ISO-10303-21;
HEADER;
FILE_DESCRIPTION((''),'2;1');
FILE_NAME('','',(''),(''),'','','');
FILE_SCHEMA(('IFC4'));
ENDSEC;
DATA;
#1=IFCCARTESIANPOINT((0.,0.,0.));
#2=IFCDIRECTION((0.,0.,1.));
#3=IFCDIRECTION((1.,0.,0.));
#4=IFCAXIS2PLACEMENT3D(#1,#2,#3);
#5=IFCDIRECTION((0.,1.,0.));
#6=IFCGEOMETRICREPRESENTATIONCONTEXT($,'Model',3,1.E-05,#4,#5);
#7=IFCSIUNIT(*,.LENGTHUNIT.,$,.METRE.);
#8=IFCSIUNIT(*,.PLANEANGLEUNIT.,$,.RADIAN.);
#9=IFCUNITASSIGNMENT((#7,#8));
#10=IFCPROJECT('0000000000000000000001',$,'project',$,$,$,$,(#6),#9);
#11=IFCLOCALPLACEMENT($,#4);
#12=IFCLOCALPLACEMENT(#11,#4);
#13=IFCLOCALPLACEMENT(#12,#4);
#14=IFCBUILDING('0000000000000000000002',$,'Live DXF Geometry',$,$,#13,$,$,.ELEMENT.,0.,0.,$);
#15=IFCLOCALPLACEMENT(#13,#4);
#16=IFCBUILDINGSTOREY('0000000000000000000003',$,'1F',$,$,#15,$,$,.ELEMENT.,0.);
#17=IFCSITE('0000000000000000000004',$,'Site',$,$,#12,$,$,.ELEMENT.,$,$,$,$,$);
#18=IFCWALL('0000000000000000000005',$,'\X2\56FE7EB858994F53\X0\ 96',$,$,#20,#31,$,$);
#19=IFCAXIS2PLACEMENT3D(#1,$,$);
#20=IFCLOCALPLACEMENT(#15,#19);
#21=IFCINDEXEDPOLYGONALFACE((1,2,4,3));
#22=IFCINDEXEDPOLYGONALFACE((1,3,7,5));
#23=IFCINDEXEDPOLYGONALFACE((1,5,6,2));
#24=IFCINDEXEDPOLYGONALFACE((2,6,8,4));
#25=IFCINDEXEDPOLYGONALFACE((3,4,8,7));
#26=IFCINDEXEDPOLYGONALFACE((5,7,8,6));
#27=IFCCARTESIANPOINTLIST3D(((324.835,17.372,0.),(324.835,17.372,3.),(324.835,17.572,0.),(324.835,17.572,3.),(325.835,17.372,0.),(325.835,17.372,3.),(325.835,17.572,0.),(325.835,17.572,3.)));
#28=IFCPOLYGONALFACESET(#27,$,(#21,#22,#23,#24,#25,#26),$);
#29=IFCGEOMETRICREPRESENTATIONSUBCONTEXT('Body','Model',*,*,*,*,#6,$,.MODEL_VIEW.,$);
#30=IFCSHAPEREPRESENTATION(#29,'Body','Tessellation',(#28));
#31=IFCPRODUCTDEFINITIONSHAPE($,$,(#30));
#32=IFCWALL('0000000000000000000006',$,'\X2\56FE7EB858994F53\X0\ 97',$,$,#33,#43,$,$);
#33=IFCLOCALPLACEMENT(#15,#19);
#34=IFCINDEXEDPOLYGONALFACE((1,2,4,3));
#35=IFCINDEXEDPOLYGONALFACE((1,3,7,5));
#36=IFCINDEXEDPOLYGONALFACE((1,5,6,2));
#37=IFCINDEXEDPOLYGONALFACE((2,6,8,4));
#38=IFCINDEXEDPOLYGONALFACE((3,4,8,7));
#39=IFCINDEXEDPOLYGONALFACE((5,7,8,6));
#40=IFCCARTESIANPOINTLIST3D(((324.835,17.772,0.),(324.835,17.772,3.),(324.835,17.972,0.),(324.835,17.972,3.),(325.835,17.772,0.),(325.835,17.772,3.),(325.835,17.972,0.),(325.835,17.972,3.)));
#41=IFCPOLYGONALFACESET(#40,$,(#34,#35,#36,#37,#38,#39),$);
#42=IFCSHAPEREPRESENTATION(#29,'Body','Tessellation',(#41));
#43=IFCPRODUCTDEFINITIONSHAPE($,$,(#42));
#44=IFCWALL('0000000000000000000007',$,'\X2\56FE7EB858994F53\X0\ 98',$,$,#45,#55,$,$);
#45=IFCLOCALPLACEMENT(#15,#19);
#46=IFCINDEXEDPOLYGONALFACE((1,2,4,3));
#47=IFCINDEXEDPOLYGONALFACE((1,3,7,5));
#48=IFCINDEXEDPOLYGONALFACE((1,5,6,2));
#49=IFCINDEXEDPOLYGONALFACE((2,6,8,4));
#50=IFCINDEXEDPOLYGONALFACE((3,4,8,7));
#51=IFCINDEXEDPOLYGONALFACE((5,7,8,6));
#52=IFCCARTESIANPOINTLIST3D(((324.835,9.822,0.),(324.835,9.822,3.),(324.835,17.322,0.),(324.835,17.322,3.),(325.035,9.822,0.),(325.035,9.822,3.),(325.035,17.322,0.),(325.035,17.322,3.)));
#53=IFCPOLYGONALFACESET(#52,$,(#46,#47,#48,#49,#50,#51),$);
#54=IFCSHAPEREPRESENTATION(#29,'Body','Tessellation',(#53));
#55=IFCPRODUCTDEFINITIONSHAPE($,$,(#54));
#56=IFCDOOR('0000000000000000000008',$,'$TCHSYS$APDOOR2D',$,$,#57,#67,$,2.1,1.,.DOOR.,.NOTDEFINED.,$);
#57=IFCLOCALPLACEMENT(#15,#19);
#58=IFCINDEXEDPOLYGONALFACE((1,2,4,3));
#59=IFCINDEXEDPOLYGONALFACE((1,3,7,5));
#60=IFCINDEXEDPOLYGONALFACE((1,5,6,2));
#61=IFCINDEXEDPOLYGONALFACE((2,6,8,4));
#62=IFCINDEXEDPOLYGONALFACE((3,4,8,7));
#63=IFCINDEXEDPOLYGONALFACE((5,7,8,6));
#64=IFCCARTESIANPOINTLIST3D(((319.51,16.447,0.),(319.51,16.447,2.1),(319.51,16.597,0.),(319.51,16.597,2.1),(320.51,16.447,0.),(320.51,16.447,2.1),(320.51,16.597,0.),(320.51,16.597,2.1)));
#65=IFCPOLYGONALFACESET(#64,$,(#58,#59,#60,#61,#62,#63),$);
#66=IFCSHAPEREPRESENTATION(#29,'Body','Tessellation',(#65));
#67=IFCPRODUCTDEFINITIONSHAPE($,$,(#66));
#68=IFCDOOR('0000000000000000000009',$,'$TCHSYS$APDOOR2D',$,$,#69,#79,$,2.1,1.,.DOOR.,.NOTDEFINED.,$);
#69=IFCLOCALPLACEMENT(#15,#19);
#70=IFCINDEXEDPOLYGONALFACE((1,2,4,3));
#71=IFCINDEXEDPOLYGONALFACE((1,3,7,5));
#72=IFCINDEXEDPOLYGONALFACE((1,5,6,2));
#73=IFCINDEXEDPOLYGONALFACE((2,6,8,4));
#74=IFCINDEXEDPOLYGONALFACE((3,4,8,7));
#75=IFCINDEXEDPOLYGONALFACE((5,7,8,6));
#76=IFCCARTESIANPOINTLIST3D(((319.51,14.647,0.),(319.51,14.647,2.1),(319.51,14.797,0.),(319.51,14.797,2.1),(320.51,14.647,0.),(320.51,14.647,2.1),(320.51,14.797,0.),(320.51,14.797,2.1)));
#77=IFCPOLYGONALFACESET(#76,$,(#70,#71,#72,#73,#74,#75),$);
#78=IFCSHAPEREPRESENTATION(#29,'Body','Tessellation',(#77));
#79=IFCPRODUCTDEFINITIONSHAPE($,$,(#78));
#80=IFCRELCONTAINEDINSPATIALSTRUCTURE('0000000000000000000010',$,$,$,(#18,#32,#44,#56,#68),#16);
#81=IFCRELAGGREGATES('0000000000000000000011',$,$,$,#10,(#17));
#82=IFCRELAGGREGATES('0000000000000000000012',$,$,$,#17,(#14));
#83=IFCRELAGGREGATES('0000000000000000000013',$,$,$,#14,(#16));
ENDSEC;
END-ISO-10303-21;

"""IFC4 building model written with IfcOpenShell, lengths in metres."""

from ifc_helpers import new_model, si_unit, direction, frame, frame_2d, origin_with_axes, place, context, subcontext, project, spatial, rectangle, extrude, element, save


model = new_model("IFC4")

# Units and contexts
model_context = context("Model", 3, precision=1e-05, world=origin_with_axes(), true_north=direction((0.0, 1.0, 0.0)))
body_context = subcontext(model_context, "Body", "Model", "MODEL_VIEW")
ifc_project = project(units=[si_unit("LENGTHUNIT", "METRE"), si_unit("PLANEANGLEUNIT", "RADIAN")], contexts=[model_context])

# Site, building, storey
placement = place(None, origin_with_axes())
site_placement = place(placement, origin_with_axes())
site = spatial("IfcSite", under=ifc_project, at=site_placement, Name="Site", CompositionType="ELEMENT")
building_placement = place(site_placement, origin_with_axes())
building = spatial("IfcBuilding", under=site, at=building_placement, Name="Live DXF Geometry", CompositionType="ELEMENT", ElevationOfRefHeight=0.0, ElevationOfTerrain=0.0)
storey_placement = place(building_placement, origin_with_axes())
storey = spatial("IfcBuildingStorey", under=building, at=storey_placement, Name="1F", CompositionType="ELEMENT", Elevation=0.0)

# Walls
for number, where, z_axis, x_axis, name in (
    (1, (325.335, 17.472, 0.0), (0.0, 0.0, 1.0), (1.0, 0.0, 0.0), "图纸墙体 96"),
    (2, (325.335, 17.872, 0.0), (0.0, 0.0, 1.0), (1.0, 0.0, 0.0), "图纸墙体 97"),
):
    element("IfcWall", number, at=place(storey_placement, frame(where, z_axis=z_axis, x_axis=x_axis)), inside=storey, Name=name, context=body_context, shape_type="SweptSolid", body=[
        extrude(rectangle(XDim=1.0, YDim=0.2, at=frame_2d((0.0, 0.0), x_axis=(1.0, 0.0, 0.0))), frame((0.0, 0.0, 0.0), z_axis=(0.0, 0.0, 1.0)), (0.0, 0.0, 1.0), 3.0),
    ])
wall_1_placement = place(storey_placement, frame((324.935, 13.572, 0.0), z_axis=(0.0, 0.0, 1.0), x_axis=(0.0, 1.0, 0.0)))
element("IfcWall", 3, at=wall_1_placement, inside=storey, Name="图纸墙体 98", context=body_context, shape_type="SweptSolid", body=[
    extrude(rectangle(XDim=7.5, YDim=0.2, at=frame_2d((0.0, 0.0), x_axis=(1.0, 0.0, 0.0))), frame((0.0, 0.0, 0.0), z_axis=(0.0, 0.0, 1.0)), (0.0, 0.0, 1.0), 3.0),
])

# Doors
for number, where, z_axis, x_axis, name in (
    (4, (320.01, 16.522, 0.0), (0.0, 0.0, 1.0), (1.0, 0.0, 0.0), "$TCHSYS$APDOOR2D"),
    (5, (320.01, 14.722, 0.0), (0.0, 0.0, 1.0), (1.0, 0.0, 0.0), "$TCHSYS$APDOOR2D"),
):
    element("IfcDoor", number, at=place(storey_placement, frame(where, z_axis=z_axis, x_axis=x_axis)), inside=storey, Name=name, OperationType="NOTDEFINED", OverallHeight=2.1, OverallWidth=1.0, PredefinedType="DOOR", context=body_context, shape_type="SweptSolid", body=[
        extrude(rectangle(XDim=1.0, YDim=0.15, at=frame_2d((0.0, 0.0), x_axis=(1.0, 0.0, 0.0))), frame((0.0, 0.0, 0.0), z_axis=(0.0, 0.0, 1.0)), (0.0, 0.0, 1.0), 2.1),
    ])

save(model, "model.ifc")
